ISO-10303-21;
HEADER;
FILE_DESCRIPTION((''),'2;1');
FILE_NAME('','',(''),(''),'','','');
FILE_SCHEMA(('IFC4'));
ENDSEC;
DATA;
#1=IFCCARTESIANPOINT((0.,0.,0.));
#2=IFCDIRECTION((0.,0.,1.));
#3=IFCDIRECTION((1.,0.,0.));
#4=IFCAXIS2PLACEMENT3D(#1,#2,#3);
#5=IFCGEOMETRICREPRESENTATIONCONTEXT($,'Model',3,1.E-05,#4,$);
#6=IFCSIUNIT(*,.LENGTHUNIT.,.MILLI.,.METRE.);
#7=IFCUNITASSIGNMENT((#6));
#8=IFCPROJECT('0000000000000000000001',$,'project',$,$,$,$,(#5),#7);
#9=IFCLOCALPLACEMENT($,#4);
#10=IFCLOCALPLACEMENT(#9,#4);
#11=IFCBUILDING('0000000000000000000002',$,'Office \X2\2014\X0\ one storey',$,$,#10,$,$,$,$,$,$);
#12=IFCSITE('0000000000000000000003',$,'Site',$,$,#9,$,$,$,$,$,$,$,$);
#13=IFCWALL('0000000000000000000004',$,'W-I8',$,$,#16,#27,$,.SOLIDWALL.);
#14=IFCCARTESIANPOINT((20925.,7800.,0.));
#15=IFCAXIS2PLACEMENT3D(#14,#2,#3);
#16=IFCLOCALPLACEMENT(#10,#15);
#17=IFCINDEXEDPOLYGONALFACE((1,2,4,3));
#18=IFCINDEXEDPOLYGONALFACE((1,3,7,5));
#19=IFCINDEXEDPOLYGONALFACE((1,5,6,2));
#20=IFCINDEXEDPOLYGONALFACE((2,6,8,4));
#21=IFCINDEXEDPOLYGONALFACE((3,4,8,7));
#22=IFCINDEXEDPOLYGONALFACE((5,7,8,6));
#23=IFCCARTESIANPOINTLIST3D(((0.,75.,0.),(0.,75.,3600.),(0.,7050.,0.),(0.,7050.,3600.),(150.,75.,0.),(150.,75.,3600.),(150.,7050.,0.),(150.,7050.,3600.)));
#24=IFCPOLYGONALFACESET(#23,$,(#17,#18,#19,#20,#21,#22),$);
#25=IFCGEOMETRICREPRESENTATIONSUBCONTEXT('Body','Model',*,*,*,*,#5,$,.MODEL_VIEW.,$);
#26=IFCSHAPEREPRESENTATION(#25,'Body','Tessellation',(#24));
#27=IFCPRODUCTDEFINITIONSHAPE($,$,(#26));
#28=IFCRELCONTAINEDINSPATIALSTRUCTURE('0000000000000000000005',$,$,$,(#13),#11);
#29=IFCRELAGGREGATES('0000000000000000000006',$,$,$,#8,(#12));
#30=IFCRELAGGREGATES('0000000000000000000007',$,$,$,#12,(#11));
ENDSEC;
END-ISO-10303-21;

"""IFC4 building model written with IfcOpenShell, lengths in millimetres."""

from ifc_helpers import new_model, si_unit, frame, frame_2d, origin, origin_with_axes, place, context, subcontext, project, spatial, rectangle, extrude, element, save


model = new_model("IFC4")

# Units and contexts
model_context = context("Model", 3, precision=1e-05, world=origin_with_axes())
body_context = subcontext(model_context, "Body", "Model", "MODEL_VIEW")
ifc_project = project(units=[si_unit("LENGTHUNIT", "METRE", prefix="MILLI")], contexts=[model_context])

# Site, building
site_placement = place(None, origin_with_axes())
site = spatial("IfcSite", under=ifc_project, at=site_placement, Name="Site")
building_placement = place(site_placement, origin_with_axes())
building = spatial("IfcBuilding", under=site, at=building_placement, Name="Office — one storey")

# Wall
wall_placement = place(building_placement, frame((20925.0, 7800.0, 0.0), z_axis=(0.0, 0.0, 1.0), x_axis=(1.0, 0.0, 0.0)))
element("IfcWall", 1, at=wall_placement, inside=building, Name="W-I8", PredefinedType="SOLIDWALL", context=body_context, shape_type="SweptSolid", body=[
    extrude(rectangle(XDim=150.0, YDim=6975.0, at=frame_2d((75.0, 3562.5))), origin(), (0.0, 0.0, 1.0), 3600.0),
])

save(model, "model.ifc")
